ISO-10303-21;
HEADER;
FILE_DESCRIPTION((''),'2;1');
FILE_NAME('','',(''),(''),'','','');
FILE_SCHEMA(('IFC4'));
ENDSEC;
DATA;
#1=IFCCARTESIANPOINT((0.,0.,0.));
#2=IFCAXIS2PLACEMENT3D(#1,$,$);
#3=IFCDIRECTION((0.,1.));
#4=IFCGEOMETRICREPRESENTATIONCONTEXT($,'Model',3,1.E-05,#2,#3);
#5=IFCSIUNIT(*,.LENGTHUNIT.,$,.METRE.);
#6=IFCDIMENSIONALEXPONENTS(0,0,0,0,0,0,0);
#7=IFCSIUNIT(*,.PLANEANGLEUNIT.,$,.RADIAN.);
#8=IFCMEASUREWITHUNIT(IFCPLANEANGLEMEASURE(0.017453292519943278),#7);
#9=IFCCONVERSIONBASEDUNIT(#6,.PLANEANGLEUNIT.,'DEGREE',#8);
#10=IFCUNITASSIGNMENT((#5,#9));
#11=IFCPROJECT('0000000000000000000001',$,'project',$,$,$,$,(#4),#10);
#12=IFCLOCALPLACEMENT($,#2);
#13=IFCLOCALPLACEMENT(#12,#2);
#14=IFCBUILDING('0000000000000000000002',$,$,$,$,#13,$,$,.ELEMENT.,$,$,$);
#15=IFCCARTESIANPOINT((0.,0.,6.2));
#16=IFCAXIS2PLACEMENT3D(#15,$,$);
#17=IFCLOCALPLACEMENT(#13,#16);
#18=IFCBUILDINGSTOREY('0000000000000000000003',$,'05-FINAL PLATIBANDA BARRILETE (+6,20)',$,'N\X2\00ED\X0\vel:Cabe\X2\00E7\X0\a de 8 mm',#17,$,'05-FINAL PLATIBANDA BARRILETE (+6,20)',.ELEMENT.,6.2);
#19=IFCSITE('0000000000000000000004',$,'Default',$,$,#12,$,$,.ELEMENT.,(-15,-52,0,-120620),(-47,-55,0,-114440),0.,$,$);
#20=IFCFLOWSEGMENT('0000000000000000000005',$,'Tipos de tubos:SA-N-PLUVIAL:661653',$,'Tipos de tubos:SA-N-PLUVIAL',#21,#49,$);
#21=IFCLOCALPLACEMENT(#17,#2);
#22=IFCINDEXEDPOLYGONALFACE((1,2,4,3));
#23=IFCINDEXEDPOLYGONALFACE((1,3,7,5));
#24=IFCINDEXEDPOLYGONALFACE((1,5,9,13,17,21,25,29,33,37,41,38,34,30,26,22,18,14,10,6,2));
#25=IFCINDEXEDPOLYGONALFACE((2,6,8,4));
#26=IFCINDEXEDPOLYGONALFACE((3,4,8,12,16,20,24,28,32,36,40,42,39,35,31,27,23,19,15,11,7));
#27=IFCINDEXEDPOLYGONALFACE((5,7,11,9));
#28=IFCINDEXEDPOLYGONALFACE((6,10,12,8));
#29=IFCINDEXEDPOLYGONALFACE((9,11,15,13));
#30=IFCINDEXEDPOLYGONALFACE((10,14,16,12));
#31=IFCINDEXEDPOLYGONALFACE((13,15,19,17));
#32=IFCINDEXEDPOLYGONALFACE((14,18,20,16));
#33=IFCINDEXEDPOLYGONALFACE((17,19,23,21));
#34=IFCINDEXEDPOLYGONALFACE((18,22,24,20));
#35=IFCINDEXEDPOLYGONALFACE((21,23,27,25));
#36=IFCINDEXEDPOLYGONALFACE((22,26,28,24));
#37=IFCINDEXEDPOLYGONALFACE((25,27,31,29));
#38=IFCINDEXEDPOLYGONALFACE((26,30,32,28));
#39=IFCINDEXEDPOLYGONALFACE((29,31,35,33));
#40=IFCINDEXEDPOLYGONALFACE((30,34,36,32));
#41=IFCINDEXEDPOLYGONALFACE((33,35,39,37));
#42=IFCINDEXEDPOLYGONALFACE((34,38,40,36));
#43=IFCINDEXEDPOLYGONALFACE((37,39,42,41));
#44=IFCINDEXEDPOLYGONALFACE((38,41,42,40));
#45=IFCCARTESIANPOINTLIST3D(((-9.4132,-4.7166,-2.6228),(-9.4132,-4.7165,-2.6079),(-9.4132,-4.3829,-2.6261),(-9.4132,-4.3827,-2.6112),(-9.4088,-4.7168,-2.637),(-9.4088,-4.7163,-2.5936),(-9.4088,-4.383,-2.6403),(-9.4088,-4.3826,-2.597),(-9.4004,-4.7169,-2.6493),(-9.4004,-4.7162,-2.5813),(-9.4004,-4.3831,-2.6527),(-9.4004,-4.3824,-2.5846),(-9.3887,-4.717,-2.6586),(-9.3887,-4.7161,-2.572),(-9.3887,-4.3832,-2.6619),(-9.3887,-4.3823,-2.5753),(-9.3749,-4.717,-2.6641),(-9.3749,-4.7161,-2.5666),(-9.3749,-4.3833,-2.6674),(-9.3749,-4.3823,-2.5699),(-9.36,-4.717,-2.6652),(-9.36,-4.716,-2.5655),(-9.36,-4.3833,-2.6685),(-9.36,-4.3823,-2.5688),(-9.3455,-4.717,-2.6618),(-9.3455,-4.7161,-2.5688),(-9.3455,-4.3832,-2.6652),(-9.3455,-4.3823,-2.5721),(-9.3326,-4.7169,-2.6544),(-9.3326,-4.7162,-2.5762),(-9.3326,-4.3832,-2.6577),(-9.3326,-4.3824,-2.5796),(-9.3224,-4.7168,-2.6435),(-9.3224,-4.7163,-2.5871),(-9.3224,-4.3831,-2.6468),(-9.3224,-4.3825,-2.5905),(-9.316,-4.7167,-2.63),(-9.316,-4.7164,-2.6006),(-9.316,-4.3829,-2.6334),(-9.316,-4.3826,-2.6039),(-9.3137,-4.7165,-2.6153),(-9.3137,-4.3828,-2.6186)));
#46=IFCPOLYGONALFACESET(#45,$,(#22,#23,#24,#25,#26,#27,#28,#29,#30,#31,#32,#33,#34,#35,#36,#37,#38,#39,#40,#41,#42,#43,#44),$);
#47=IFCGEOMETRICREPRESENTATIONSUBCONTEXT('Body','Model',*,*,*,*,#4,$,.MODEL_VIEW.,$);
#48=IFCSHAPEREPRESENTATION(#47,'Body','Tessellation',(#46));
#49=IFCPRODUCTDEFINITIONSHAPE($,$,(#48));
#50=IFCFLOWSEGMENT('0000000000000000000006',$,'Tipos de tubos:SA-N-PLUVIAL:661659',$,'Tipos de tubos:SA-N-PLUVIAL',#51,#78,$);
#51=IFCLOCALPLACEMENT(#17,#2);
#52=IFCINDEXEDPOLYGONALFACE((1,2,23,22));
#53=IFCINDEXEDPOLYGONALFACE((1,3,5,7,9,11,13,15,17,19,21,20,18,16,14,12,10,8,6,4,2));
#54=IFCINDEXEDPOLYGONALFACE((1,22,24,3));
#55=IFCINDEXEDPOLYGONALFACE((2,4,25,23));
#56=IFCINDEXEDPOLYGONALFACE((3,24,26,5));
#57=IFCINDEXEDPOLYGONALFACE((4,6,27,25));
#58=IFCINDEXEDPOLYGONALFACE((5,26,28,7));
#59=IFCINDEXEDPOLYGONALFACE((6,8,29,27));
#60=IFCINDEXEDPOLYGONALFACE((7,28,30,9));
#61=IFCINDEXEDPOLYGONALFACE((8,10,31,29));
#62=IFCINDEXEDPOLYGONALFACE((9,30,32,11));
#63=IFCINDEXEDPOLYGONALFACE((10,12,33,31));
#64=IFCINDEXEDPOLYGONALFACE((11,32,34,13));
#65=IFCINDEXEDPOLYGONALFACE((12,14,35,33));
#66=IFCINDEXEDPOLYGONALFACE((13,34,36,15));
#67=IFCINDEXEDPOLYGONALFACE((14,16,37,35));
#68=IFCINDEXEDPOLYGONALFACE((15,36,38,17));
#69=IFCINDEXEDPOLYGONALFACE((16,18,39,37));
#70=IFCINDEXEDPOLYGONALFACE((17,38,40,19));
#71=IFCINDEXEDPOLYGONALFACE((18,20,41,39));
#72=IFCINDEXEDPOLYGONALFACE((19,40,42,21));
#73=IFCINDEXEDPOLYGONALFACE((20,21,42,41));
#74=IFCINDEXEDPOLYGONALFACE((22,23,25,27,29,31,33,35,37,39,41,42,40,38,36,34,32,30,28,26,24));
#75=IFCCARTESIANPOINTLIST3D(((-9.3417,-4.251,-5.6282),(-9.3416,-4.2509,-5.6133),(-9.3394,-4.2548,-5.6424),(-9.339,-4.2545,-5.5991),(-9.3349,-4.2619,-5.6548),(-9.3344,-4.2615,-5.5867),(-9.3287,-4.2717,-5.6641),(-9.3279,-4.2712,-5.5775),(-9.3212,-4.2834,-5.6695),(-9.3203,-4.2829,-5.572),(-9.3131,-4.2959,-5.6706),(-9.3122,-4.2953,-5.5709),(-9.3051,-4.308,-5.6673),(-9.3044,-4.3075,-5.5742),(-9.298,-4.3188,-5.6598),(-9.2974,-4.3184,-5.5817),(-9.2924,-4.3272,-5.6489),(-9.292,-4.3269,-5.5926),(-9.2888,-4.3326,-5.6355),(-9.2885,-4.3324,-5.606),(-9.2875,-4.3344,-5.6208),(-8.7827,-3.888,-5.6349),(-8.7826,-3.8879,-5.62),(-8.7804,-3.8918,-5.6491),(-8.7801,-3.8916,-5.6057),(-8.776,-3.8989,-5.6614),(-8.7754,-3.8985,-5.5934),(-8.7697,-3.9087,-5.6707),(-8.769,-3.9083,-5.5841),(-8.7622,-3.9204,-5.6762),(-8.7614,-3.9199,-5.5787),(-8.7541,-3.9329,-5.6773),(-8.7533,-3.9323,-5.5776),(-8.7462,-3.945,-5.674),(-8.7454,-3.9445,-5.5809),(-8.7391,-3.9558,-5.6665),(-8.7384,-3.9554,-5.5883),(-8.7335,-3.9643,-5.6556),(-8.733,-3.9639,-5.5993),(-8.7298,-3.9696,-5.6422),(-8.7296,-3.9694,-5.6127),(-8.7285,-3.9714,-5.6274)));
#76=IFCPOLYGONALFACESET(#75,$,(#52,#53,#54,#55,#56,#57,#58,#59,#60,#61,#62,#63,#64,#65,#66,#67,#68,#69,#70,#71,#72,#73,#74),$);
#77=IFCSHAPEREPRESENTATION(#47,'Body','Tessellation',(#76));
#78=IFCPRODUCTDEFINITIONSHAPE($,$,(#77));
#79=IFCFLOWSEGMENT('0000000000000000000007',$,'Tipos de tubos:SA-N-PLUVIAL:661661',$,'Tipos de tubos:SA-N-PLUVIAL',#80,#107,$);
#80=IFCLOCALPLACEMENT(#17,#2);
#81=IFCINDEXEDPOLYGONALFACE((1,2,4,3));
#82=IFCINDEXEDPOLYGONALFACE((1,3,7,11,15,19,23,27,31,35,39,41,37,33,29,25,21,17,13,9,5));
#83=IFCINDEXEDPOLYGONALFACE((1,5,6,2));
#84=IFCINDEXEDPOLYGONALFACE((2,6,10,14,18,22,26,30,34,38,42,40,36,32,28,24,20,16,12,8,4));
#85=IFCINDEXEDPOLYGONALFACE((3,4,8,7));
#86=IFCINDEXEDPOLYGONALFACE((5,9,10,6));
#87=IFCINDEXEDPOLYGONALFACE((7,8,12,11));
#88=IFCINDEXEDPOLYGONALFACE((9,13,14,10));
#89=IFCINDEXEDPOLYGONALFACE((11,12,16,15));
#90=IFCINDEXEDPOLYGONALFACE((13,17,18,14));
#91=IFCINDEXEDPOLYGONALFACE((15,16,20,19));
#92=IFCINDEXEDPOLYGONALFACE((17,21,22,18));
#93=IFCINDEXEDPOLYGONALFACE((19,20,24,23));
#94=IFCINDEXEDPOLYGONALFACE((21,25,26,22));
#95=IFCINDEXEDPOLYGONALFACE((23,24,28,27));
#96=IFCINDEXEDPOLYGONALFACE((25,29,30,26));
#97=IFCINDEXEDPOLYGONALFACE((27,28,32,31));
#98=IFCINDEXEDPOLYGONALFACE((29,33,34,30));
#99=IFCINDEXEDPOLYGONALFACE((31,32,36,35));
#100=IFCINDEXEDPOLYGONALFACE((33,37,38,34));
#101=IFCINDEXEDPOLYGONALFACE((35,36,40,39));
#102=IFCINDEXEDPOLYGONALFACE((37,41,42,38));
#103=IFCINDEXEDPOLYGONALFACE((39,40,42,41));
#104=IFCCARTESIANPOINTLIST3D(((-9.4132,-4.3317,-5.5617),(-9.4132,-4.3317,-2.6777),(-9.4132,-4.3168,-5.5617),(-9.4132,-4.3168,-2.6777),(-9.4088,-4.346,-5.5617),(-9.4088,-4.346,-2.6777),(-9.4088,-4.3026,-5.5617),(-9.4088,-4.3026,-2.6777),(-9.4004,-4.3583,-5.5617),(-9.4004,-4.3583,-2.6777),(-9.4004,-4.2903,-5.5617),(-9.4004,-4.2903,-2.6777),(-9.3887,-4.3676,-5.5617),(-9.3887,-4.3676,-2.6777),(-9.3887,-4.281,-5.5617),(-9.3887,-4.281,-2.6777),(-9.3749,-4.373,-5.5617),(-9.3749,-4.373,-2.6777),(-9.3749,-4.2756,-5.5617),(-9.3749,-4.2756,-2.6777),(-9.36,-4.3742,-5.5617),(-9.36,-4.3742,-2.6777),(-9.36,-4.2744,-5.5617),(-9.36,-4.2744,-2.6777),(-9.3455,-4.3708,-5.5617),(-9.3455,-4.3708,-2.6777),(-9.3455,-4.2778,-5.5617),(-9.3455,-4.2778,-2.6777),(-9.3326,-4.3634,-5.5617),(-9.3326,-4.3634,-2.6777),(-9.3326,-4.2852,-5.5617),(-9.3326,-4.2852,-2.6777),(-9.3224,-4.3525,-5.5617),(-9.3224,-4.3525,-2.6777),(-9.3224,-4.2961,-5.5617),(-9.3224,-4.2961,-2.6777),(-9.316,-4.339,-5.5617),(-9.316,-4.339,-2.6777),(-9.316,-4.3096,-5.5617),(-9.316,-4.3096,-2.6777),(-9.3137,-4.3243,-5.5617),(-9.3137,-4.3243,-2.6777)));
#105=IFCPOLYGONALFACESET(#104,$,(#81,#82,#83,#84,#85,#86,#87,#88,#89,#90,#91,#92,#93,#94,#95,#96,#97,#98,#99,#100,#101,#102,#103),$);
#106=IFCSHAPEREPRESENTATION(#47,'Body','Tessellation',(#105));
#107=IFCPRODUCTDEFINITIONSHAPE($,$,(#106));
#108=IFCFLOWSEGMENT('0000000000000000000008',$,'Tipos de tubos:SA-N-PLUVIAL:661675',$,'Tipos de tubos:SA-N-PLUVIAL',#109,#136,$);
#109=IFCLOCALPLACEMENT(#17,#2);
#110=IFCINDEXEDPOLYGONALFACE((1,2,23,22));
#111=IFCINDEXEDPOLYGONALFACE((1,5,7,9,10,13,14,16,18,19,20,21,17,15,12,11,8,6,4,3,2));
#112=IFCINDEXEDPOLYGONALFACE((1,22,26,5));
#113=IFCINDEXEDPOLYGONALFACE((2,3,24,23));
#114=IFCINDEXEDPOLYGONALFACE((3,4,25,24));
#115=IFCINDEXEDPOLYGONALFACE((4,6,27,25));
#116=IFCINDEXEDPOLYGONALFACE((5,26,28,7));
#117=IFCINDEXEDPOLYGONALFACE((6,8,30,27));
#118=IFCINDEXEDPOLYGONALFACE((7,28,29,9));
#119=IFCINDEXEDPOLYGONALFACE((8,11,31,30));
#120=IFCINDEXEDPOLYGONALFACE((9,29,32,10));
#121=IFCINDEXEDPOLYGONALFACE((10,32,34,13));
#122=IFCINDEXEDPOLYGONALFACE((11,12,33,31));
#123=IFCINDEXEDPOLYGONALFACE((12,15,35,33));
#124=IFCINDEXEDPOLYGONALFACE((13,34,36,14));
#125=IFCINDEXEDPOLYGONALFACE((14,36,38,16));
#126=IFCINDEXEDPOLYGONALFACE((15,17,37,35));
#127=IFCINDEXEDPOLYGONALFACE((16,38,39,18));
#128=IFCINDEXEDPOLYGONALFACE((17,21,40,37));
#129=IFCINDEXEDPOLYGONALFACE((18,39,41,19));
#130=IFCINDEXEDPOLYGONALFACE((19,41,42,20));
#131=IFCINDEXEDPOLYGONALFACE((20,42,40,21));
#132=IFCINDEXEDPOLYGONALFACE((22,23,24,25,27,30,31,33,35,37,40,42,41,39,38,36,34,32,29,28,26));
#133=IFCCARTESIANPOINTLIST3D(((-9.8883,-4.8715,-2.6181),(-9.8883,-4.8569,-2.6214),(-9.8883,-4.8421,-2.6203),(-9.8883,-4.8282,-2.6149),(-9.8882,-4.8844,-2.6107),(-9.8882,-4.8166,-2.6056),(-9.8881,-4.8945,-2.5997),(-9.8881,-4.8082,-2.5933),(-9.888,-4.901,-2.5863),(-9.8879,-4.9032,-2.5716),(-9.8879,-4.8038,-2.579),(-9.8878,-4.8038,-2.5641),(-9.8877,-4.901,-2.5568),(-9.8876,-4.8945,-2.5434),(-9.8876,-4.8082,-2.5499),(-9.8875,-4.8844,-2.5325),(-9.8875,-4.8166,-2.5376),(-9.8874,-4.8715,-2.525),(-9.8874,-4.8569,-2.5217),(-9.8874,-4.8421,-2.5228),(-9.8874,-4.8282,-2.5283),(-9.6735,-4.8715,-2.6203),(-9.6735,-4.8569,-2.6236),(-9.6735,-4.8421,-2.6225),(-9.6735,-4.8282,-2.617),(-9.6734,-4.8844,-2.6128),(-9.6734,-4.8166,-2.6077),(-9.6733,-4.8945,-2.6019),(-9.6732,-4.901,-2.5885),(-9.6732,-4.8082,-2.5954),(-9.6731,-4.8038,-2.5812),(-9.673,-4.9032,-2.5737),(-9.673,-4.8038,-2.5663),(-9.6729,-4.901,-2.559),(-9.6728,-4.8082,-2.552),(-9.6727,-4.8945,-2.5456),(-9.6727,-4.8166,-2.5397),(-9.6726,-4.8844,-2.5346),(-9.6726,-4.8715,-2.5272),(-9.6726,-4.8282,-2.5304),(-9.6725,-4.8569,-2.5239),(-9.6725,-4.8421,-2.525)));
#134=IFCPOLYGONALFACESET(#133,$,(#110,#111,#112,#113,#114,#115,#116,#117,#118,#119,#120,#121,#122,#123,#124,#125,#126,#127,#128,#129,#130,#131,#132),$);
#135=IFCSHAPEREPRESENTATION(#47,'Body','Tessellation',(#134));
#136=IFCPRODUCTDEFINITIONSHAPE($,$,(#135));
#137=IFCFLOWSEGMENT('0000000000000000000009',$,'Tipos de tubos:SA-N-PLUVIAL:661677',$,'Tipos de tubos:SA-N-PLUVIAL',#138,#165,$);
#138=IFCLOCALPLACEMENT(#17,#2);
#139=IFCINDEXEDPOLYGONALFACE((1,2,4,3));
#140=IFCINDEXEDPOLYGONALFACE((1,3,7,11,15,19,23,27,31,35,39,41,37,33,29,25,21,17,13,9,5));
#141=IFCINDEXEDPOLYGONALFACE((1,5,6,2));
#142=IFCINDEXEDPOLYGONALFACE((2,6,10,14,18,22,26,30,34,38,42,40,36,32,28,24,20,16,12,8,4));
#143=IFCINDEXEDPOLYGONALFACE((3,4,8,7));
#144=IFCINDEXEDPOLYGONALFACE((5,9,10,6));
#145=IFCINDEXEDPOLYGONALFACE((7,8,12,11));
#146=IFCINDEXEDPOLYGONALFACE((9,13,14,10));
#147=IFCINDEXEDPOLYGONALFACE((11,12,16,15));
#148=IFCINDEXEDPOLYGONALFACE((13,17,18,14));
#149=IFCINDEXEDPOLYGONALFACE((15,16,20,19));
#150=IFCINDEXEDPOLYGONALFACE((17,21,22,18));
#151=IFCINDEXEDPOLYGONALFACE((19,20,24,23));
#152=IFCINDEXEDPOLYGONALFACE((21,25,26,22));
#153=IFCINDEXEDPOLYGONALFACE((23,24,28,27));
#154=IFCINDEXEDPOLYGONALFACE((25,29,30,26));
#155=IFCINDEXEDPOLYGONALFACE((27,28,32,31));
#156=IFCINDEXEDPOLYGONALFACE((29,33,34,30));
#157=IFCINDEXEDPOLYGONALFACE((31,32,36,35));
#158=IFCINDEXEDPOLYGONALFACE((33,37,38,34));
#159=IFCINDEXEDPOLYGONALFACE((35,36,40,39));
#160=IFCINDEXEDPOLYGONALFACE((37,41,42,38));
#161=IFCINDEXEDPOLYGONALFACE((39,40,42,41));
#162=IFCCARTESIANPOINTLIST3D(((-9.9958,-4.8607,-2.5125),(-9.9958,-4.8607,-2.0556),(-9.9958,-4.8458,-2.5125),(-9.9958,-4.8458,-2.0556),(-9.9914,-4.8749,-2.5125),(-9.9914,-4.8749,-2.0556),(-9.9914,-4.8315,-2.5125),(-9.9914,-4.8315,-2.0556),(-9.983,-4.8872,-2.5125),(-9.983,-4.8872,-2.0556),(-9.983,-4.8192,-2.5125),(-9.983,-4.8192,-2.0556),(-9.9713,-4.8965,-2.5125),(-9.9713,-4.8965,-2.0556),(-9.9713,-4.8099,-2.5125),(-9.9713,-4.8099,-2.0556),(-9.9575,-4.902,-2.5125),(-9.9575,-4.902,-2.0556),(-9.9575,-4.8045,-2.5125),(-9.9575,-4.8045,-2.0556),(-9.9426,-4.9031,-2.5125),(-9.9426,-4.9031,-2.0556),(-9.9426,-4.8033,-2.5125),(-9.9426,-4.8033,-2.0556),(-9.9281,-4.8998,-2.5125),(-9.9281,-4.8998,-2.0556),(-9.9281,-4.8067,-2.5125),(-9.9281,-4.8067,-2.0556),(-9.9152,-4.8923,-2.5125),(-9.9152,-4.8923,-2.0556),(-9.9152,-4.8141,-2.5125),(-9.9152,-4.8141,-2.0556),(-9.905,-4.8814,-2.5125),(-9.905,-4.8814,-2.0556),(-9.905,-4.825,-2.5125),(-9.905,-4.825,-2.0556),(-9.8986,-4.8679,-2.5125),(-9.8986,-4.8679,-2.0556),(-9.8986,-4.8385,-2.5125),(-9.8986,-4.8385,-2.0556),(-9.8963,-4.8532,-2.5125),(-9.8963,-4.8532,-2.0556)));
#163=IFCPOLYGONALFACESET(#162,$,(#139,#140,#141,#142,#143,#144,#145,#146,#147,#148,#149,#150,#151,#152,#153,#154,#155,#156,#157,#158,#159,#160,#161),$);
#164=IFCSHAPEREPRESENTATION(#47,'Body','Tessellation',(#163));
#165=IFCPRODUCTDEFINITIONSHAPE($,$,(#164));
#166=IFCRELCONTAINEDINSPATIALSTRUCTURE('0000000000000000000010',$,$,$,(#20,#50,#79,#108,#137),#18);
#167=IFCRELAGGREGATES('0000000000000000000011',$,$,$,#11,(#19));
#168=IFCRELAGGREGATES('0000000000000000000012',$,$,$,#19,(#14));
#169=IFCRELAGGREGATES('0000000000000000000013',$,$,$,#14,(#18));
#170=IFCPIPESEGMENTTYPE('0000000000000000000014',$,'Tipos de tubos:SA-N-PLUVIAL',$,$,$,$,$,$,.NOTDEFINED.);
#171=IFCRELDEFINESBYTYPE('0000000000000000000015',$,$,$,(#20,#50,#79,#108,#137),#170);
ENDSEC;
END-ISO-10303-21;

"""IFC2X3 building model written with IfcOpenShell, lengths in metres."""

from ifc_helpers import new_model, entity, si_unit, converted_unit, direction, frame, frame_2d, origin, origin_2d_with_axis, place, context, subcontext, project, spatial, circle, extrude, type_object, element, save


model = new_model("IFC2X3")

# Units and contexts
model_context = context("Model", 3, precision=1e-05, world=origin(), true_north=direction((0.0, 1.0)))
body_context = subcontext(model_context, "Body", "Model", "MODEL_VIEW")
ifc_project = project(units=[si_unit("LENGTHUNIT", "METRE"), converted_unit("PLANEANGLEUNIT", "DEGREE", entity("IfcPlaneAngleMeasure", 0.017453292519943278), si_unit("PLANEANGLEUNIT", "RADIAN"), dimensions=[0, 0, 0, 0, 0, 0, 0])], contexts=[model_context])

# Site, building, storey
site_placement = place(None, origin())
site = spatial("IfcSite", under=ifc_project, at=site_placement, Name="Default", CompositionType="ELEMENT", RefLatitude=(-15, -52, 0, -120620), RefLongitude=(-47, -55, 0, -114440), RefElevation=0.0)
building_placement = place(site_placement, origin())
building = spatial("IfcBuilding", under=site, at=building_placement, CompositionType="ELEMENT")
storey_placement = place(building_placement, frame((0.0, 0.0, 6.2)))
storey = spatial("IfcBuildingStorey", under=building, at=storey_placement, Name="05-FINAL PLATIBANDA BARRILETE (+6,20)", ObjectType="Nível:Cabeça de 8 mm", LongName="05-FINAL PLATIBANDA BARRILETE (+6,20)", CompositionType="ELEMENT", Elevation=6.2)

# Flow segments
pipe_segment_type = type_object("IfcPipeSegmentType", Name="Tipos de tubos:SA-N-PLUVIAL", PredefinedType="NOTDEFINED")
flow_segment_1_placement = place(storey_placement, origin())
element("IfcFlowSegment", 1, at=flow_segment_1_placement, inside=storey, type_object=pipe_segment_type, Name="Tipos de tubos:SA-N-PLUVIAL:661653", ObjectType="Tipos de tubos:SA-N-PLUVIAL", context=body_context, shape_type="SweptSolid", body=[
    extrude(circle(Radius=0.05, at=origin_2d_with_axis()), frame((-9.3637, -4.3828, -2.6186), z_axis=(0.000001, -0.99995, 0.01), x_axis=(1.0, 0.000001, 0.0)), (0.0, 0.0, 1.0), 0.3338),
])
flow_segment_2_placement = place(storey_placement, origin())
element("IfcFlowSegment", 2, at=flow_segment_2_placement, inside=storey, type_object=pipe_segment_type, Name="Tipos de tubos:SA-N-PLUVIAL:661659", ObjectType="Tipos de tubos:SA-N-PLUVIAL", context=body_context, shape_type="SweptSolid", body=[
    extrude(circle(Radius=0.05, at=frame_2d((0.0, 0.0), x_axis=(1.0, 0.0))), frame((-9.3147, -4.2924, -5.6208), z_axis=(0.838628, 0.544612, -0.01), x_axis=(0.54464, -0.83867, 0.0)), (0.0, 0.0, 1.0), 0.6665),
])
flow_segment_3_placement = place(storey_placement, origin())
element("IfcFlowSegment", 3, at=flow_segment_3_placement, inside=storey, type_object=pipe_segment_type, Name="Tipos de tubos:SA-N-PLUVIAL:661661", ObjectType="Tipos de tubos:SA-N-PLUVIAL", context=body_context, shape_type="SweptSolid", body=[
    extrude(circle(Radius=0.05, at=origin_2d_with_axis()), frame((-9.3637, -4.3243, -5.5617)), (0.0, 0.0, 1.0), 2.884),
])
flow_segment_4_placement = place(storey_placement, origin())
element("IfcFlowSegment", 4, at=flow_segment_4_placement, inside=storey, type_object=pipe_segment_type, Name="Tipos de tubos:SA-N-PLUVIAL:661675", ObjectType="Tipos de tubos:SA-N-PLUVIAL", context=body_context, shape_type="SweptSolid", body=[
    extrude(circle(Radius=0.05, at=frame_2d((0.0, 0.0), x_axis=(1.0, 0.0))), frame((-9.673, -4.8532, -2.5737), z_axis=(-0.99995, -0.000001, 0.01), x_axis=(0.000001, -1.0, 0.0)), (0.0, 0.0, 1.0), 0.2148),
])
flow_segment_5_placement = place(storey_placement, origin())
element("IfcFlowSegment", 5, at=flow_segment_5_placement, inside=storey, type_object=pipe_segment_type, Name="Tipos de tubos:SA-N-PLUVIAL:661677", ObjectType="Tipos de tubos:SA-N-PLUVIAL", context=body_context, shape_type="SweptSolid", body=[
    extrude(circle(Radius=0.05, at=frame_2d((0.0, 0.0), x_axis=(1.0, 0.0))), frame((-9.9463, -4.8532, -2.5125)), (0.0, 0.0, 1.0), 0.4569),
])

save(model, "model.ifc")
